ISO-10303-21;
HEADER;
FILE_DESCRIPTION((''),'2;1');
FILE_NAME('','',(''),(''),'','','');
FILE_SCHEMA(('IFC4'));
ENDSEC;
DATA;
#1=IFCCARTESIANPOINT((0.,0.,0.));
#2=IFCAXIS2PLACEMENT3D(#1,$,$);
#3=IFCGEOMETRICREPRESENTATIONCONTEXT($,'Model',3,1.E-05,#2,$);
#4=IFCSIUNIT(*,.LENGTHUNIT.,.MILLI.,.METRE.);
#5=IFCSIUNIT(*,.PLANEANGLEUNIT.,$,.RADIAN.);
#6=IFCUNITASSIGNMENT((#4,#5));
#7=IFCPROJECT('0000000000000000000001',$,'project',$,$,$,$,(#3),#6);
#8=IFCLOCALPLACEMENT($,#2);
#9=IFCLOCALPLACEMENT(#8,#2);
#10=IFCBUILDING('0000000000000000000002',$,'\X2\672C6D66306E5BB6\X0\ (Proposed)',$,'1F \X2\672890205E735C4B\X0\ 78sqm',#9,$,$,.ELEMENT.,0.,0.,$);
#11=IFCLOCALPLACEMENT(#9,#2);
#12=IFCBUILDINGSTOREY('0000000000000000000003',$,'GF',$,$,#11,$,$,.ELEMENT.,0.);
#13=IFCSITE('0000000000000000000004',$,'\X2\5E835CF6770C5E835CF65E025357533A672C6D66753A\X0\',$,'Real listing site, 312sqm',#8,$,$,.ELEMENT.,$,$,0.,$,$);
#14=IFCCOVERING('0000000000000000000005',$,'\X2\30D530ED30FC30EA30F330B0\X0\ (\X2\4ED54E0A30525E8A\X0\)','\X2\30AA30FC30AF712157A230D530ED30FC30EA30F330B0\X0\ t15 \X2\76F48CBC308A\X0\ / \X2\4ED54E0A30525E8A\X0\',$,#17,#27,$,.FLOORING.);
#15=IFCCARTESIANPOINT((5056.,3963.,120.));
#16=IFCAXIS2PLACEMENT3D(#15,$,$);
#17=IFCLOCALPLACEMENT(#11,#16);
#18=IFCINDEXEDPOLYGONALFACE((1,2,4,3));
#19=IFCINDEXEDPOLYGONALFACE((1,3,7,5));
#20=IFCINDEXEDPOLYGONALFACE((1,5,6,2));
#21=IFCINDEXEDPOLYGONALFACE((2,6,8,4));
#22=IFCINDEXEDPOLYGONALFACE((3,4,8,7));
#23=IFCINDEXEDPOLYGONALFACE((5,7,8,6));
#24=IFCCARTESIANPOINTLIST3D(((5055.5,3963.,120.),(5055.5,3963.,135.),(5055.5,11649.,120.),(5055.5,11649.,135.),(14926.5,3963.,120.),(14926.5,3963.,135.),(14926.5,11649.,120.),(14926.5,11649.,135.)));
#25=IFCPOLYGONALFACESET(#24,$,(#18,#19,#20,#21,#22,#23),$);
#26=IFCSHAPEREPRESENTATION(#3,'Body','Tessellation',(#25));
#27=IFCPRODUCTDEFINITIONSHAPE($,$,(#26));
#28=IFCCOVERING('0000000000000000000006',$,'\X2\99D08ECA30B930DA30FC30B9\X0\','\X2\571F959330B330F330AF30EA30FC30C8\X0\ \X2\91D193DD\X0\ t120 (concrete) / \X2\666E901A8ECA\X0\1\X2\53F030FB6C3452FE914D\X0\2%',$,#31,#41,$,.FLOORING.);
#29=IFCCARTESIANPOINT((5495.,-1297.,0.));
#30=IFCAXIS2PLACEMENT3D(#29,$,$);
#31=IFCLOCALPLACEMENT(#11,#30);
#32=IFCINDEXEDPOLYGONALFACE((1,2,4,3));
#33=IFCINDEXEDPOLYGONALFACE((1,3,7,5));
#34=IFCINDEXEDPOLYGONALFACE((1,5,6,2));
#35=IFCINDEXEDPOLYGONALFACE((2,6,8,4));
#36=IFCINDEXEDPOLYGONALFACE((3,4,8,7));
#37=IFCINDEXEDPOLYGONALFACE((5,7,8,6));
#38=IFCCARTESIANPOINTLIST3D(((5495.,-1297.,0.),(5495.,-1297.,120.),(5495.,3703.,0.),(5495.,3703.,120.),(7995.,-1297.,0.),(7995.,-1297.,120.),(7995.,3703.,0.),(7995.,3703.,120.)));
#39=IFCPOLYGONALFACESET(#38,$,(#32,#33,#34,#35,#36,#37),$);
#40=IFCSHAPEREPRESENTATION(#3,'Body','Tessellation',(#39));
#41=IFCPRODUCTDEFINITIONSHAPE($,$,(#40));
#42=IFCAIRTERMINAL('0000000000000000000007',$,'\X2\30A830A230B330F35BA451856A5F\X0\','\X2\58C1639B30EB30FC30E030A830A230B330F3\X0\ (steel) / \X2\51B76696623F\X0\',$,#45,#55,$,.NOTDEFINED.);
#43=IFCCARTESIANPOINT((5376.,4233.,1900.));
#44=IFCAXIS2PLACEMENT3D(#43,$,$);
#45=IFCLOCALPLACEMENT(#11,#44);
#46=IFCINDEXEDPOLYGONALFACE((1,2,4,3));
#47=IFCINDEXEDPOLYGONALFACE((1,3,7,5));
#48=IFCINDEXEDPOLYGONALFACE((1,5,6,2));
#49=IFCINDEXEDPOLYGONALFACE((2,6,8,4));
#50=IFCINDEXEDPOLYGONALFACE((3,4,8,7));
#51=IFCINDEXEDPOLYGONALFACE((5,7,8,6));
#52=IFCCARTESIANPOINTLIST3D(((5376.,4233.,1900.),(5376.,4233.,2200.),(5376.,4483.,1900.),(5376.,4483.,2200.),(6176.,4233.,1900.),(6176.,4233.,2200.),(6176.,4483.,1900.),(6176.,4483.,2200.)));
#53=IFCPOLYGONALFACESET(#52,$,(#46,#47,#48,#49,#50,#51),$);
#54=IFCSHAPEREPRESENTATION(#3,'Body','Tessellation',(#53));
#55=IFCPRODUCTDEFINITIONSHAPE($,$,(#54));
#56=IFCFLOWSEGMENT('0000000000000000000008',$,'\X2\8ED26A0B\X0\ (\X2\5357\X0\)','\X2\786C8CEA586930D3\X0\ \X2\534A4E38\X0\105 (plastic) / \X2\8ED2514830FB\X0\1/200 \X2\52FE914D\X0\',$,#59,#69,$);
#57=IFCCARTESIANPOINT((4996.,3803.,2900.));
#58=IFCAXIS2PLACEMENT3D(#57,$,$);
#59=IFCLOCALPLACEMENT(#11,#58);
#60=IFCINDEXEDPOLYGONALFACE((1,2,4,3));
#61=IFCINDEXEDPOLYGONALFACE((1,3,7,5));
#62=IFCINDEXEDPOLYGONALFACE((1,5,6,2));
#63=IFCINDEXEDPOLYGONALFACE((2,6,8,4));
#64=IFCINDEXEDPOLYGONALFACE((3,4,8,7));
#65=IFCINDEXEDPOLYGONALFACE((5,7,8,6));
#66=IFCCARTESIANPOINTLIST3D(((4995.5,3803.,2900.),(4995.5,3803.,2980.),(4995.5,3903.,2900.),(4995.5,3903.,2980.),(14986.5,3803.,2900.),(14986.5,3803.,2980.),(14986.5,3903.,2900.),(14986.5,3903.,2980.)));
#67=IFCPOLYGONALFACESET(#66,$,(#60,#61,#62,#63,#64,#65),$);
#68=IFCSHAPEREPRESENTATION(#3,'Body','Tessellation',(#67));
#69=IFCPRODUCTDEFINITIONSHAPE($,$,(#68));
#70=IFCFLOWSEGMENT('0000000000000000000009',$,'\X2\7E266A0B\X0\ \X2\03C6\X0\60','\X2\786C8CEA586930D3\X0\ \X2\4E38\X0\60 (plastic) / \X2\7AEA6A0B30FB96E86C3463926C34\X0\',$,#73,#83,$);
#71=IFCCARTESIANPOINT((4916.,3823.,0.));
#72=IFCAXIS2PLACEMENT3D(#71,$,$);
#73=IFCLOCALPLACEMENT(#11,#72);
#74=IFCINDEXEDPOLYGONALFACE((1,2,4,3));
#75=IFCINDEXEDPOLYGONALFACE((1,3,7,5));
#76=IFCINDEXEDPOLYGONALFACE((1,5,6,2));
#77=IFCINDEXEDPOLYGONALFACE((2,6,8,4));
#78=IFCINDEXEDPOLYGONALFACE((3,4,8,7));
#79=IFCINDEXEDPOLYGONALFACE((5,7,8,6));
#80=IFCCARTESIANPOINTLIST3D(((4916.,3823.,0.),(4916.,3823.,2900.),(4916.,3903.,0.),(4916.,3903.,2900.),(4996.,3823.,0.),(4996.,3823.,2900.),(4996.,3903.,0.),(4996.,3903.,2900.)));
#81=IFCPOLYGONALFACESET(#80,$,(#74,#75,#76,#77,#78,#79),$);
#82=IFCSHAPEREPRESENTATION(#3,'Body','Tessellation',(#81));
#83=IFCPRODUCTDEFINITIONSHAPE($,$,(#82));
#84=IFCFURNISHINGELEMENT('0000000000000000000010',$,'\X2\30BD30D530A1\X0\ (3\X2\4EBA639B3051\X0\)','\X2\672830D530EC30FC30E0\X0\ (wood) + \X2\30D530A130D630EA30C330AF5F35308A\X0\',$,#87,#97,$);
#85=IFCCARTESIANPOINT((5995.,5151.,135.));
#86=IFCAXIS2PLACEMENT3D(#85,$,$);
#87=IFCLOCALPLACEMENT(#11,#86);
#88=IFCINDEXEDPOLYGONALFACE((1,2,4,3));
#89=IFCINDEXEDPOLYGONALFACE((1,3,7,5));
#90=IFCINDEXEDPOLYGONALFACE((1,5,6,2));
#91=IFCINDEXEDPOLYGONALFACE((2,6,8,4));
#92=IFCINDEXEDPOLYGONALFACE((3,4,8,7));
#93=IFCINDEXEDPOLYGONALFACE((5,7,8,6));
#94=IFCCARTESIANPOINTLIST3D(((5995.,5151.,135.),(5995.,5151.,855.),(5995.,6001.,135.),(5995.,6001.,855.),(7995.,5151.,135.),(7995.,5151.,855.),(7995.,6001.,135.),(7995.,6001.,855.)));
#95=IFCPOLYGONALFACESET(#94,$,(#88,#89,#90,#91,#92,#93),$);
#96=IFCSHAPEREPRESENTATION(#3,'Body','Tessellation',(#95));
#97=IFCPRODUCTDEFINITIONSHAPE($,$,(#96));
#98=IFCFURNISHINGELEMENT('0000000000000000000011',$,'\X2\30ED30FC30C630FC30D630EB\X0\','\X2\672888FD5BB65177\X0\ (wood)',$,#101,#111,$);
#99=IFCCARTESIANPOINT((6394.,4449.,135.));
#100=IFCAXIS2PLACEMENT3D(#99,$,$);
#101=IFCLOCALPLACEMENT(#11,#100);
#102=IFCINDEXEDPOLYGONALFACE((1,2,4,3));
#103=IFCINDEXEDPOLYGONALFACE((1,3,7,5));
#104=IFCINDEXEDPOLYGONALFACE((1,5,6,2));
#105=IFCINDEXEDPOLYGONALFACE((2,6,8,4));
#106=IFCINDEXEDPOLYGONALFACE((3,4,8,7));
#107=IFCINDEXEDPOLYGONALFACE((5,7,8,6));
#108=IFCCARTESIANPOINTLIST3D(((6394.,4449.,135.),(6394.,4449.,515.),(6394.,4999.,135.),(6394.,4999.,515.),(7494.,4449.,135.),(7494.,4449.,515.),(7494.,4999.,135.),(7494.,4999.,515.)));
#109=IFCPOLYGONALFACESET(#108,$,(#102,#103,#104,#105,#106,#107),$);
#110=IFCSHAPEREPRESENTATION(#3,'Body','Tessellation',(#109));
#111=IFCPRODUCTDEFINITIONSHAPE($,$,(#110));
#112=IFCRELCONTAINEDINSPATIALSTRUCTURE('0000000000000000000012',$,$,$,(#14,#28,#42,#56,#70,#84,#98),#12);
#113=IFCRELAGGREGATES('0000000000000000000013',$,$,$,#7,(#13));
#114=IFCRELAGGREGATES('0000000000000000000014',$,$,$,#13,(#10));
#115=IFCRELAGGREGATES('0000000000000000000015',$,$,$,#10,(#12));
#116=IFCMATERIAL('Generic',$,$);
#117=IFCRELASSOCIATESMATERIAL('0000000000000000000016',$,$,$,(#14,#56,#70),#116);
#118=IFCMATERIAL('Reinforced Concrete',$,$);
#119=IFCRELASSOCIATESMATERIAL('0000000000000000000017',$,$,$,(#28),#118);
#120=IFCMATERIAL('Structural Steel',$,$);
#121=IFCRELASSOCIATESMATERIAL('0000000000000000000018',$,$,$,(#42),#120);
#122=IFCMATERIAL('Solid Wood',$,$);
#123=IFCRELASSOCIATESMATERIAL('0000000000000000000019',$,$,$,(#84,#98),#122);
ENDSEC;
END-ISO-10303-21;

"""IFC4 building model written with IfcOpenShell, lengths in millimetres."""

from ifc_helpers import new_model, si_unit, frame, frame_2d, origin, place, context, project, spatial, rectangle, extrude, material, element, save


model = new_model("IFC4")

# Units and contexts
model_context = context("Model", 3, precision=1e-05, world=origin())
ifc_project = project(units=[si_unit("LENGTHUNIT", "METRE", prefix="MILLI"), si_unit("PLANEANGLEUNIT", "RADIAN")], contexts=[model_context])

# Site, building, storey
site_placement = place(None, origin())
site = spatial("IfcSite", under=ifc_project, at=site_placement, Name="広島県広島市南区本浦町", ObjectType="Real listing site, 312sqm", CompositionType="ELEMENT", RefElevation=0.0)
building_placement = place(site_placement, origin())
building = spatial("IfcBuilding", under=site, at=building_placement, Name="本浦の家 (Proposed)", ObjectType="1F 木造平屋 78sqm", CompositionType="ELEMENT", ElevationOfRefHeight=0.0, ElevationOfTerrain=0.0)
storey_placement = place(building_placement, origin())
storey = spatial("IfcBuildingStorey", under=building, at=storey_placement, Name="GF", CompositionType="ELEMENT", Elevation=0.0)

# Shared definitions
ifc_material_1 = material(Name="Solid Wood")

# Shared definitions
ifc_material_2 = material(Name="Reinforced Concrete")

# Shared definitions
ifc_material_3 = material(Name="Structural Steel")

# Coverings
ifc_material_4 = material(Name="Generic")
covering_1_placement = place(storey_placement, frame((5056.0, 3963.0, 120.0)))
element("IfcCovering", 1, at=covering_1_placement, inside=storey, material=ifc_material_4, Name="フローリング (仕上げ床)", Description="オーク無垢フローリング t15 直貼り / 仕上げ床", PredefinedType="FLOORING", context=model_context, shape_type="SweptSolid", body=[
    extrude(rectangle(XDim=9871.0, YDim=7686.0, at=frame_2d((4935.0, 3843.0))), frame((5056.0, 3963.0, 120.0)), (0.0, 0.0, 1.0), 15.0),
])
covering_2_placement = place(storey_placement, frame((5495.0, -1297.0, 0.0)))
element("IfcCovering", 2, at=covering_2_placement, inside=storey, material=ifc_material_2, Name="駐車スペース", Description="土間コンクリート 金鏝 t120 (concrete) / 普通車1台・水勾配2%", PredefinedType="FLOORING", context=model_context, shape_type="SweptSolid", body=[
    extrude(rectangle(XDim=2500.0, YDim=5000.0, at=frame_2d((1250.0, 2500.0))), frame((5495.0, -1297.0, 0.0)), (0.0, 0.0, 1.0), 120.0),
])

# Air terminal
air_terminal_placement = place(storey_placement, frame((5376.0, 4233.0, 1900.0)))
element("IfcAirTerminal", 3, at=air_terminal_placement, inside=storey, material=ifc_material_3, Name="エアコン室内機", Description="壁掛ルームエアコン (steel) / 冷暖房", PredefinedType="NOTDEFINED", context=model_context, shape_type="SweptSolid", body=[
    extrude(rectangle(XDim=800.0, YDim=250.0, at=frame_2d((400.0, 125.0))), frame((5376.0, 4233.0, 1900.0)), (0.0, 0.0, 1.0), 300.0),
])

# Flow segments
flow_segment_1_placement = place(storey_placement, frame((4996.0, 3803.0, 2900.0)))
element("IfcFlowSegment", 4, at=flow_segment_1_placement, inside=storey, material=ifc_material_4, Name="軒樋 (南)", Description="硬質塩ビ 半丸105 (plastic) / 軒先・1/200 勾配", context=model_context, shape_type="SweptSolid", body=[
    extrude(rectangle(XDim=9991.0, YDim=100.0, at=frame_2d((4995.0, 50.0))), frame((4996.0, 3803.0, 2900.0)), (0.0, 0.0, 1.0), 80.0),
])
flow_segment_2_placement = place(storey_placement, frame((4916.0, 3823.0, 0.0)))
element("IfcFlowSegment", 5, at=flow_segment_2_placement, inside=storey, material=ifc_material_4, Name="縦樋 φ60", Description="硬質塩ビ 丸60 (plastic) / 竪樋・雨水排水", context=model_context, shape_type="SweptSolid", body=[
    extrude(rectangle(XDim=80.0, YDim=80.0, at=frame_2d((40.0, 40.0))), frame((4916.0, 3823.0, 0.0)), (0.0, 0.0, 1.0), 2900.0),
])

# Furnishing elements
furnishing_1_placement = place(storey_placement, frame((5995.0, 5151.0, 135.0)))
element("IfcFurnishingElement", 6, at=furnishing_1_placement, inside=storey, material=ifc_material_1, Name="ソファ (3人掛け)", Description="木フレーム (wood) + ファブリック張り", context=model_context, shape_type="SweptSolid", body=[
    extrude(rectangle(XDim=2000.0, YDim=850.0, at=frame_2d((1000.0, 425.0))), frame((5995.0, 5151.0, 135.0)), (0.0, 0.0, 1.0), 720.0),
])
furnishing_2_placement = place(storey_placement, frame((6394.0, 4449.0, 135.0)))
element("IfcFurnishingElement", 7, at=furnishing_2_placement, inside=storey, material=ifc_material_1, Name="ローテーブル", Description="木製家具 (wood)", context=model_context, shape_type="SweptSolid", body=[
    extrude(rectangle(XDim=1100.0, YDim=550.0, at=frame_2d((550.0, 275.0))), frame((6394.0, 4449.0, 135.0)), (0.0, 0.0, 1.0), 380.0),
])

save(model, "model.ifc")
